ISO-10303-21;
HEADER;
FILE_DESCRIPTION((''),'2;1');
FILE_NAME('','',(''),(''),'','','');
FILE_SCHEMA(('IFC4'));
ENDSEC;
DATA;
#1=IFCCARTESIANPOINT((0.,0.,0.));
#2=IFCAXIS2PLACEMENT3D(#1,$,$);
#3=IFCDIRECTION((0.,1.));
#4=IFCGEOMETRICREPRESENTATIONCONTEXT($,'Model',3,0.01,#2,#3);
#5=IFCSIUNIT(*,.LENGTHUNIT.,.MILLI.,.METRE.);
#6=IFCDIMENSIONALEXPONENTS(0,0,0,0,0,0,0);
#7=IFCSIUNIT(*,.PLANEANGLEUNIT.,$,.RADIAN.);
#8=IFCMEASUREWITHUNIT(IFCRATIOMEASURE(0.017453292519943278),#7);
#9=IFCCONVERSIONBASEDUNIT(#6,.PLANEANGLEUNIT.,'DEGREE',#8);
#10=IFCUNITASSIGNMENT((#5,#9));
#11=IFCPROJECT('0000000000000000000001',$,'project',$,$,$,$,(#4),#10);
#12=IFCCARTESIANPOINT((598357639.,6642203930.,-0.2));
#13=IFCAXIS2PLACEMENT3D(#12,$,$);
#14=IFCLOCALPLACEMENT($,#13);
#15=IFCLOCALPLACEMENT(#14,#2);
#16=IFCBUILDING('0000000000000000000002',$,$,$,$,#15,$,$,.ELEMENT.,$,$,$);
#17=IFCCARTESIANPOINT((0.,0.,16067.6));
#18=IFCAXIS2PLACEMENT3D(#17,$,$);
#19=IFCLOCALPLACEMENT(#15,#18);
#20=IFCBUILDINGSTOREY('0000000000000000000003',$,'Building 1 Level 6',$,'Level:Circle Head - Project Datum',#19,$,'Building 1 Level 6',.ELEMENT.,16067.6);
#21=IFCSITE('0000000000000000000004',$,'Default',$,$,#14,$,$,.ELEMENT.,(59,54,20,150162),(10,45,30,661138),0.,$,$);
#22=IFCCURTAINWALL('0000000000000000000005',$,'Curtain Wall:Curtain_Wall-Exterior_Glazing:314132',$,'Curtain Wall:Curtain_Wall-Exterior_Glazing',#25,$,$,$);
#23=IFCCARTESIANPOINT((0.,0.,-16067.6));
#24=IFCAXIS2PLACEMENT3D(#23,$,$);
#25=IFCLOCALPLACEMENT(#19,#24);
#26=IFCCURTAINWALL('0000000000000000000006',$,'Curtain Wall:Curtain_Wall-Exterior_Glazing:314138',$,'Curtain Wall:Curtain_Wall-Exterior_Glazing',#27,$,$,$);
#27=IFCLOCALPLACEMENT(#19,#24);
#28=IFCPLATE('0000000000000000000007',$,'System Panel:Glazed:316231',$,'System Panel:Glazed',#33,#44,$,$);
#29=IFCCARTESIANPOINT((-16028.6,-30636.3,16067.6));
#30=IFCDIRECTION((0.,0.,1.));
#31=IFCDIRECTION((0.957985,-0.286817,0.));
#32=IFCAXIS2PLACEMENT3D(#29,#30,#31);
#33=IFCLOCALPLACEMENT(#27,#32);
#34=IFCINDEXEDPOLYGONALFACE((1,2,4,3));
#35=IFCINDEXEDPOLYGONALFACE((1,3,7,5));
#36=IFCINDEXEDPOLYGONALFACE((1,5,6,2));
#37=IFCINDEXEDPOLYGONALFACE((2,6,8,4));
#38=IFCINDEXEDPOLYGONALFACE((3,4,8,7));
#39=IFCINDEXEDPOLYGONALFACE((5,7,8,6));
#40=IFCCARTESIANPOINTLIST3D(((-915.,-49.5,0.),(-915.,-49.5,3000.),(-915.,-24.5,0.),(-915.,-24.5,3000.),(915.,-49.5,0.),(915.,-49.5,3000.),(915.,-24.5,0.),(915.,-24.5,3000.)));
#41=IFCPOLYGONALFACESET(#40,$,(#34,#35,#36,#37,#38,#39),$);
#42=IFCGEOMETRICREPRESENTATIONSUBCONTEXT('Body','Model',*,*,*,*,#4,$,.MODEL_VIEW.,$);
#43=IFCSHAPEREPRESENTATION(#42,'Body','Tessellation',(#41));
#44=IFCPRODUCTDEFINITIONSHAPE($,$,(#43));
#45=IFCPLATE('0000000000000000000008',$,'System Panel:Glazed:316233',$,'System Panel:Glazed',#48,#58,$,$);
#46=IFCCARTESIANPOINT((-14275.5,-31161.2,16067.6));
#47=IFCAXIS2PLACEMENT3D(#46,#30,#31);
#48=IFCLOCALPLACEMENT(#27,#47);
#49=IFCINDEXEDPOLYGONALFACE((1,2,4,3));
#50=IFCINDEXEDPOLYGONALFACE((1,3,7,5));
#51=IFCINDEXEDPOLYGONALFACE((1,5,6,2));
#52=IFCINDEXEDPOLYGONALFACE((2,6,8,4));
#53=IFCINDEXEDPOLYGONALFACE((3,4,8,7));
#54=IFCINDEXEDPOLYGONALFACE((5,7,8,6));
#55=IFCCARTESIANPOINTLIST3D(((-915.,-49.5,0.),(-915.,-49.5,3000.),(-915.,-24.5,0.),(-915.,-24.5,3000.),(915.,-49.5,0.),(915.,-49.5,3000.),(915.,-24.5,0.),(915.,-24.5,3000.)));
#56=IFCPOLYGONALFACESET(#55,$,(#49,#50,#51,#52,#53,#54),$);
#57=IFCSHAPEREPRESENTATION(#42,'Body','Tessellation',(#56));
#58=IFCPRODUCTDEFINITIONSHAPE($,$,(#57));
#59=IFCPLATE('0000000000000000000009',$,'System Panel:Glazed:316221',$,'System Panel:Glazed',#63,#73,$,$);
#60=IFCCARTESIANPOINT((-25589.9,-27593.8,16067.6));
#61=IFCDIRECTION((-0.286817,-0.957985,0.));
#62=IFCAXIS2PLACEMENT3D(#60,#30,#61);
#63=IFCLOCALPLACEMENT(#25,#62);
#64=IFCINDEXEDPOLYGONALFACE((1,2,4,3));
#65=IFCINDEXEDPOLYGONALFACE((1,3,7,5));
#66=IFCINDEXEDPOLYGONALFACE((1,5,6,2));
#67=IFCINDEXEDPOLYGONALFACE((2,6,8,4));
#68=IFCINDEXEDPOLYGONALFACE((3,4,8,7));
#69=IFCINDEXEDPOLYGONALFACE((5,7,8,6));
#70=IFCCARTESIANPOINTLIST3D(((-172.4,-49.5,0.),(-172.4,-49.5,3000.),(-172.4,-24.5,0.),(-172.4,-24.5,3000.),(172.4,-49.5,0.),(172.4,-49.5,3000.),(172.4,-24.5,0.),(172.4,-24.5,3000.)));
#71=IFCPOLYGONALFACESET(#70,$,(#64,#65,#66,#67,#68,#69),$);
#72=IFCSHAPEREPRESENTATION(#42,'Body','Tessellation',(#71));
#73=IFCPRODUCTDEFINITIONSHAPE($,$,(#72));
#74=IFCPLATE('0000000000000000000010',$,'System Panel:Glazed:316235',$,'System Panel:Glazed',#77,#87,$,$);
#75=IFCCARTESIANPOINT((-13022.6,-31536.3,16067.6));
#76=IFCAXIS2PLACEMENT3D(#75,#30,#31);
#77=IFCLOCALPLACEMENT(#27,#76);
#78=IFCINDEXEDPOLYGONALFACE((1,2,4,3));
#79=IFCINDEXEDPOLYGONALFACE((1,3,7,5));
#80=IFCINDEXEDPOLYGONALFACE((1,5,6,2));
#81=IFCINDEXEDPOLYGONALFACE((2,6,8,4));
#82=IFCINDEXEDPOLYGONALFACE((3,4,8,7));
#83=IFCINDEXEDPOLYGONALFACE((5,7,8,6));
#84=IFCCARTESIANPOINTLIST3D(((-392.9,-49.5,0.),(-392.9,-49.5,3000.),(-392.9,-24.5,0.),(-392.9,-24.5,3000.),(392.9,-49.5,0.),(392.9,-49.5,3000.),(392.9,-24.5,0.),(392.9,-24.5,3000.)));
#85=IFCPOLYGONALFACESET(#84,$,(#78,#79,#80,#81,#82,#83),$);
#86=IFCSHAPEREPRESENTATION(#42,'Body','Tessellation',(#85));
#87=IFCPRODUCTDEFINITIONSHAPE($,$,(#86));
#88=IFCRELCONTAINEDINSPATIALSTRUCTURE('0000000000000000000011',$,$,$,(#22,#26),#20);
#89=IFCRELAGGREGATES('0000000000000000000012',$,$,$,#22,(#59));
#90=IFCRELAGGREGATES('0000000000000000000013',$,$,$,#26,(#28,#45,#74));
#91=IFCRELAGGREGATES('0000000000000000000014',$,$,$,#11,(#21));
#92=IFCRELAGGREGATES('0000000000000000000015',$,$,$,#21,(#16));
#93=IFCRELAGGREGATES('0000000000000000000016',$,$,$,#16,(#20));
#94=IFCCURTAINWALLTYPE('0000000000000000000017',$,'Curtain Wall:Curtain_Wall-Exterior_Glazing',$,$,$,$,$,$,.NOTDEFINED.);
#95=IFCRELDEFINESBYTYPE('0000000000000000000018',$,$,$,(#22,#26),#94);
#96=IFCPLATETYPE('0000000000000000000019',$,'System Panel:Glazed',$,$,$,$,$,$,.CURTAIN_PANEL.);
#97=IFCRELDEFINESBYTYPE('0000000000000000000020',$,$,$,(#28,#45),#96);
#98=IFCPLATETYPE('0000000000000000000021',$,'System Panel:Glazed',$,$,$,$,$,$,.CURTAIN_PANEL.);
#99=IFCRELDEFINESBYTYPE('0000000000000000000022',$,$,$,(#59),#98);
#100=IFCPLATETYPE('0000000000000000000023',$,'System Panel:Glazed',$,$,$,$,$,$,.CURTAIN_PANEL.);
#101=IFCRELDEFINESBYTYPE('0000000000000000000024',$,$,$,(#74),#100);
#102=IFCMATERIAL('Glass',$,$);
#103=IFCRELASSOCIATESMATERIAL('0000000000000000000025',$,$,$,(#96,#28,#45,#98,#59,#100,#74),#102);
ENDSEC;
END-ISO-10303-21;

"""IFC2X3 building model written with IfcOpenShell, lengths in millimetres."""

from ifc_helpers import new_model, entity, si_unit, converted_unit, direction, frame, frame_2d, origin, place, context, subcontext, project, spatial, rectangle, extrude, source, transform, mapped, material, type_object, type_shapes, element, aggregate, save


model = new_model("IFC2X3")

# Units and contexts
model_context = context("Model", 3, precision=0.01, world=origin(), true_north=direction((0.0, 1.0)))
body_context = subcontext(model_context, "Body", "Model", "MODEL_VIEW")
ifc_project = project(units=[si_unit("LENGTHUNIT", "METRE", prefix="MILLI"), converted_unit("PLANEANGLEUNIT", "DEGREE", entity("IfcRatioMeasure", 0.017453292519943278), si_unit("PLANEANGLEUNIT", "RADIAN"), dimensions=[0, 0, 0, 0, 0, 0, 0])], contexts=[model_context])

# Site, building, storey
site_placement = place(None, frame((598357639.0, 6642203930.0, -0.2)))
site = spatial("IfcSite", under=ifc_project, at=site_placement, Name="Default", CompositionType="ELEMENT", RefLatitude=(59, 54, 20, 150162), RefLongitude=(10, 45, 30, 661138), RefElevation=0.0)
building_placement = place(site_placement, origin())
building = spatial("IfcBuilding", under=site, at=building_placement, CompositionType="ELEMENT")
storey_placement = place(building_placement, frame((0.0, 0.0, 16067.6)))
storey = spatial("IfcBuildingStorey", under=building, at=storey_placement, Name="Building 1 Level 6", ObjectType="Level:Circle Head - Project Datum", LongName="Building 1 Level 6", CompositionType="ELEMENT", Elevation=16067.6)

# Curtain walls, plates
curtain_wall_type = type_object("IfcCurtainWallType", Name="Curtain Wall:Curtain_Wall-Exterior_Glazing", PredefinedType="NOTDEFINED")
curtain_wall_1_placement = place(storey_placement, frame((0.0, 0.0, -16067.6)))
curtain_wall_1 = element("IfcCurtainWall", 1, at=curtain_wall_1_placement, inside=storey, type_object=curtain_wall_type, Name="Curtain Wall:Curtain_Wall-Exterior_Glazing:314132", ObjectType="Curtain Wall:Curtain_Wall-Exterior_Glazing")
ifc_material_1 = material(Name="Glass")
plate_type_1 = type_object("IfcPlateType", Name="System Panel:Glazed", PredefinedType="CURTAIN_PANEL", material=ifc_material_1)
shared_shape_1 = source(origin(), body_context, "Body", "SweptSolid", [
    extrude(rectangle(XDim=25.0, YDim=1830.0, at=frame_2d((0.0, 0.0), x_axis=(1.0, 0.0))), frame((0.0, -37.0, 0.0), z_axis=(0.0, 0.0, 1.0), x_axis=(0.0, 1.0, 0.0)), (0.0, 0.0, 1.0), 3000.0),
])
type_shapes(plate_type_1, [shared_shape_1])
curtain_wall_2_placement = place(storey_placement, frame((0.0, 0.0, -16067.6)))
curtain_wall_2 = element("IfcCurtainWall", 2, at=curtain_wall_2_placement, inside=storey, type_object=curtain_wall_type, Name="Curtain Wall:Curtain_Wall-Exterior_Glazing:314138", ObjectType="Curtain Wall:Curtain_Wall-Exterior_Glazing")
plate_1_placement = place(curtain_wall_2_placement, frame((-16028.6, -30636.3, 16067.6), z_axis=(0.0, 0.0, 1.0), x_axis=(0.957985, -0.286817, 0.0)))
plate_1 = element("IfcPlate", 3, at=plate_1_placement, type_object=plate_type_1, material=ifc_material_1, Name="System Panel:Glazed:316231", ObjectType="System Panel:Glazed", context=body_context, shape_type="MappedRepresentation", body=[
    mapped(shared_shape_1, transform((0.0, 0.0, 0.0), scale=1.0)),
])
plate_2_placement = place(curtain_wall_2_placement, frame((-14275.5, -31161.2, 16067.6), z_axis=(0.0, 0.0, 1.0), x_axis=(0.957985, -0.286817, 0.0)))
plate_2 = element("IfcPlate", 4, at=plate_2_placement, type_object=plate_type_1, material=ifc_material_1, Name="System Panel:Glazed:316233", ObjectType="System Panel:Glazed", context=body_context, shape_type="MappedRepresentation", body=[
    mapped(shared_shape_1, transform((0.0, 0.0, 0.0), scale=1.0)),
])

# Plates
plate_type_2 = type_object("IfcPlateType", Name="System Panel:Glazed", PredefinedType="CURTAIN_PANEL", material=ifc_material_1)
shared_shape_2 = source(origin(), body_context, "Body", "SweptSolid", [
    extrude(rectangle(XDim=25.0, YDim=344.8, at=frame_2d((0.0, 0.0), x_axis=(1.0, 0.0))), frame((0.0, -37.0, 0.0), z_axis=(0.0, 0.0, 1.0), x_axis=(0.0, 1.0, 0.0)), (0.0, 0.0, 1.0), 3000.0),
])
type_shapes(plate_type_2, [shared_shape_2])
plate_3_placement = place(curtain_wall_1_placement, frame((-25589.9, -27593.8, 16067.6), z_axis=(0.0, 0.0, 1.0), x_axis=(-0.286817, -0.957985, 0.0)))
plate_3 = element("IfcPlate", 5, at=plate_3_placement, type_object=plate_type_2, material=ifc_material_1, Name="System Panel:Glazed:316221", ObjectType="System Panel:Glazed", context=body_context, shape_type="MappedRepresentation", body=[
    mapped(shared_shape_2, transform((0.0, 0.0, 0.0), scale=1.0)),
])
aggregate(curtain_wall_1, [plate_3])
plate_type_3 = type_object("IfcPlateType", Name="System Panel:Glazed", PredefinedType="CURTAIN_PANEL", material=ifc_material_1)
shared_shape_3 = source(origin(), body_context, "Body", "SweptSolid", [
    extrude(rectangle(XDim=25.0, YDim=785.7, at=frame_2d((0.0, 0.0), x_axis=(1.0, 0.0))), frame((0.0, -37.0, 0.0), z_axis=(0.0, 0.0, 1.0), x_axis=(0.0, 1.0, 0.0)), (0.0, 0.0, 1.0), 3000.0),
])
type_shapes(plate_type_3, [shared_shape_3])
plate_4_placement = place(curtain_wall_2_placement, frame((-13022.6, -31536.3, 16067.6), z_axis=(0.0, 0.0, 1.0), x_axis=(0.957985, -0.286817, 0.0)))
plate_4 = element("IfcPlate", 6, at=plate_4_placement, type_object=plate_type_3, material=ifc_material_1, Name="System Panel:Glazed:316235", ObjectType="System Panel:Glazed", context=body_context, shape_type="MappedRepresentation", body=[
    mapped(shared_shape_3, transform((0.0, 0.0, 0.0), scale=1.0)),
])
aggregate(curtain_wall_2, [plate_1, plate_2, plate_4])

save(model, "model.ifc")
